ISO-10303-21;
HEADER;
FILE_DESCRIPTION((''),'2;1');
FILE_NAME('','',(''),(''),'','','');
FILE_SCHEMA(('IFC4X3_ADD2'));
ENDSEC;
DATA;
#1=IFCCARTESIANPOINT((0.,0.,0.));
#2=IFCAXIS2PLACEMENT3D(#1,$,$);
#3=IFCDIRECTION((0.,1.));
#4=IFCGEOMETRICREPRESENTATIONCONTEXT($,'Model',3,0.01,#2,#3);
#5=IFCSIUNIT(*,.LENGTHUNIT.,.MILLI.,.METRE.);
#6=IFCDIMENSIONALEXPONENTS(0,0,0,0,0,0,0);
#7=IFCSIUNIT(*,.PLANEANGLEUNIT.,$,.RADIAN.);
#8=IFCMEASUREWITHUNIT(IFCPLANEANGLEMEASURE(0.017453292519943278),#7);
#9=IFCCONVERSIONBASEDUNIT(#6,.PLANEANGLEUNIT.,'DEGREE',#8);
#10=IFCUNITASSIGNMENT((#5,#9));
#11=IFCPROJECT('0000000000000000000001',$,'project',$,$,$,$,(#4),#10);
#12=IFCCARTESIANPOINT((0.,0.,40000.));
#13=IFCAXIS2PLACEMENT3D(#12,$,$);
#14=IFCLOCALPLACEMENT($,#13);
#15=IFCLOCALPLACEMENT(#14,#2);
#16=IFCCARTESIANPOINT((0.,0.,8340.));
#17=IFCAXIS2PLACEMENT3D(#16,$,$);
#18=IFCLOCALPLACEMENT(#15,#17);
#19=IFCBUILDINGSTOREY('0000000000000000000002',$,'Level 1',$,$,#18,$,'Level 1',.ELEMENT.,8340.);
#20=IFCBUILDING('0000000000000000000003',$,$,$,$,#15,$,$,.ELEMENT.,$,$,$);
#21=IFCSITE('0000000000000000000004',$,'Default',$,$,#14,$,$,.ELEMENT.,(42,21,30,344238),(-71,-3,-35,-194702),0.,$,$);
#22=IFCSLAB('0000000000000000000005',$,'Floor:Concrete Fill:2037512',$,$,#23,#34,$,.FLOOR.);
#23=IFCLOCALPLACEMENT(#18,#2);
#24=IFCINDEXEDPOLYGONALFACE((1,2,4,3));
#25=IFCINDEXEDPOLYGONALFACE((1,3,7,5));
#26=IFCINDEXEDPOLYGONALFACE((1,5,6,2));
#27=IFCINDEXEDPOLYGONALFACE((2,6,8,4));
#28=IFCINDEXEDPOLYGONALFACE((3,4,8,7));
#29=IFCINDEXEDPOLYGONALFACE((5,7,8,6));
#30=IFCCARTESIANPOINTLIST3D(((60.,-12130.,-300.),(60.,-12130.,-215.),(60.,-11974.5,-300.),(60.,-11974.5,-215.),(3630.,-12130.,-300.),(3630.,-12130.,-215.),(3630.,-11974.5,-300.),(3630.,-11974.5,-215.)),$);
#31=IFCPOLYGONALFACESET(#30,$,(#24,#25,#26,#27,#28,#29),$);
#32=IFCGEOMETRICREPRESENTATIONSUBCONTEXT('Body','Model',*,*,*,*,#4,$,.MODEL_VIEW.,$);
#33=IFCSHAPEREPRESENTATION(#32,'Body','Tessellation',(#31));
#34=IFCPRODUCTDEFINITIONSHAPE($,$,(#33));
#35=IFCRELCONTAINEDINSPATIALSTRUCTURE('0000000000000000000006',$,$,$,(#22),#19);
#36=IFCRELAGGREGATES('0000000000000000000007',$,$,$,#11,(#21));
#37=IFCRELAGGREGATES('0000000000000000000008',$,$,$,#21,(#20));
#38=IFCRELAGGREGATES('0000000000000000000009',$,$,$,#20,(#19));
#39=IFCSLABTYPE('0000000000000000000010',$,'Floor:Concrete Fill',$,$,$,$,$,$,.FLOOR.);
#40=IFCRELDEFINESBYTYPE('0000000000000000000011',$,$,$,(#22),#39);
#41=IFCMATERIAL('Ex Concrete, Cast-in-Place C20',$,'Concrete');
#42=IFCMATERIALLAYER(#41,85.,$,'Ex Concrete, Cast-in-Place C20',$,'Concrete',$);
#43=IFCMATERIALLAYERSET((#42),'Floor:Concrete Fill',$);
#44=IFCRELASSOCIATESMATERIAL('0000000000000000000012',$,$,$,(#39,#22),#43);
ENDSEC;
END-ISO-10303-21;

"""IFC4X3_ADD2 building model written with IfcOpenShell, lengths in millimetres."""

from ifc_helpers import new_model, entity, si_unit, converted_unit, direction, frame, origin, origin_2d_with_axis, place, context, subcontext, project, spatial, rectangle, extrude, material, layer, layer_set, layer_usage, type_object, element, save


model = new_model("IFC4X3_ADD2")

# Units and contexts
model_context = context("Model", 3, precision=0.01, world=origin(), true_north=direction((0.0, 1.0)))
body_context = subcontext(model_context, "Body", "Model", "MODEL_VIEW")
ifc_project = project(units=[si_unit("LENGTHUNIT", "METRE", prefix="MILLI"), converted_unit("PLANEANGLEUNIT", "DEGREE", entity("IfcPlaneAngleMeasure", 0.017453292519943278), si_unit("PLANEANGLEUNIT", "RADIAN"), dimensions=[0, 0, 0, 0, 0, 0, 0])], contexts=[model_context])

# Site, building, storey
site_placement = place(None, frame((0.0, 0.0, 40000.0)))
site = spatial("IfcSite", under=ifc_project, at=site_placement, Name="Default", CompositionType="ELEMENT", RefLatitude=(42, 21, 30, 344238), RefLongitude=(-71, -3, -35, -194702), RefElevation=0.0)
building_placement = place(site_placement, origin())
building = spatial("IfcBuilding", under=site, at=building_placement, CompositionType="ELEMENT")
storey_placement = place(building_placement, frame((0.0, 0.0, 8340.0)))
storey = spatial("IfcBuildingStorey", under=building, at=storey_placement, Name="Level 1", LongName="Level 1", CompositionType="ELEMENT", Elevation=8340.0)

# Slab
ifc_material_1 = material(Name="Ex Concrete, Cast-in-Place C20", Category="Concrete")
ifc_layer_1 = layer(ifc_material_1, 85.0, Name="Ex Concrete, Cast-in-Place C20", Category="Concrete")
ifc_layer_set_1 = layer_set([ifc_layer_1], Name="Floor:Concrete Fill")
ifc_layer_usage_1 = layer_usage(ifc_layer_set_1, "AXIS3", "POSITIVE", 0.0)
slab_type_1 = type_object("IfcSlabType", Name="Floor:Concrete Fill", PredefinedType="FLOOR", material=ifc_layer_set_1)
slab_1_placement = place(storey_placement, origin())
element("IfcSlab", 1, at=slab_1_placement, inside=storey, type_object=slab_type_1, material=ifc_layer_usage_1, Name="Floor:Concrete Fill:2037512", PredefinedType="FLOOR", context=body_context, shape_type="SweptSolid", body=[
    extrude(rectangle(XDim=155.5, YDim=3570.0, at=origin_2d_with_axis()), frame((1845.0, -12052.3, -215.0), z_axis=(0.0, 0.0, -1.0), x_axis=(0.0, 1.0, 0.0)), (0.0, 0.0, 1.0), 85.0),
])

save(model, "model.ifc")
